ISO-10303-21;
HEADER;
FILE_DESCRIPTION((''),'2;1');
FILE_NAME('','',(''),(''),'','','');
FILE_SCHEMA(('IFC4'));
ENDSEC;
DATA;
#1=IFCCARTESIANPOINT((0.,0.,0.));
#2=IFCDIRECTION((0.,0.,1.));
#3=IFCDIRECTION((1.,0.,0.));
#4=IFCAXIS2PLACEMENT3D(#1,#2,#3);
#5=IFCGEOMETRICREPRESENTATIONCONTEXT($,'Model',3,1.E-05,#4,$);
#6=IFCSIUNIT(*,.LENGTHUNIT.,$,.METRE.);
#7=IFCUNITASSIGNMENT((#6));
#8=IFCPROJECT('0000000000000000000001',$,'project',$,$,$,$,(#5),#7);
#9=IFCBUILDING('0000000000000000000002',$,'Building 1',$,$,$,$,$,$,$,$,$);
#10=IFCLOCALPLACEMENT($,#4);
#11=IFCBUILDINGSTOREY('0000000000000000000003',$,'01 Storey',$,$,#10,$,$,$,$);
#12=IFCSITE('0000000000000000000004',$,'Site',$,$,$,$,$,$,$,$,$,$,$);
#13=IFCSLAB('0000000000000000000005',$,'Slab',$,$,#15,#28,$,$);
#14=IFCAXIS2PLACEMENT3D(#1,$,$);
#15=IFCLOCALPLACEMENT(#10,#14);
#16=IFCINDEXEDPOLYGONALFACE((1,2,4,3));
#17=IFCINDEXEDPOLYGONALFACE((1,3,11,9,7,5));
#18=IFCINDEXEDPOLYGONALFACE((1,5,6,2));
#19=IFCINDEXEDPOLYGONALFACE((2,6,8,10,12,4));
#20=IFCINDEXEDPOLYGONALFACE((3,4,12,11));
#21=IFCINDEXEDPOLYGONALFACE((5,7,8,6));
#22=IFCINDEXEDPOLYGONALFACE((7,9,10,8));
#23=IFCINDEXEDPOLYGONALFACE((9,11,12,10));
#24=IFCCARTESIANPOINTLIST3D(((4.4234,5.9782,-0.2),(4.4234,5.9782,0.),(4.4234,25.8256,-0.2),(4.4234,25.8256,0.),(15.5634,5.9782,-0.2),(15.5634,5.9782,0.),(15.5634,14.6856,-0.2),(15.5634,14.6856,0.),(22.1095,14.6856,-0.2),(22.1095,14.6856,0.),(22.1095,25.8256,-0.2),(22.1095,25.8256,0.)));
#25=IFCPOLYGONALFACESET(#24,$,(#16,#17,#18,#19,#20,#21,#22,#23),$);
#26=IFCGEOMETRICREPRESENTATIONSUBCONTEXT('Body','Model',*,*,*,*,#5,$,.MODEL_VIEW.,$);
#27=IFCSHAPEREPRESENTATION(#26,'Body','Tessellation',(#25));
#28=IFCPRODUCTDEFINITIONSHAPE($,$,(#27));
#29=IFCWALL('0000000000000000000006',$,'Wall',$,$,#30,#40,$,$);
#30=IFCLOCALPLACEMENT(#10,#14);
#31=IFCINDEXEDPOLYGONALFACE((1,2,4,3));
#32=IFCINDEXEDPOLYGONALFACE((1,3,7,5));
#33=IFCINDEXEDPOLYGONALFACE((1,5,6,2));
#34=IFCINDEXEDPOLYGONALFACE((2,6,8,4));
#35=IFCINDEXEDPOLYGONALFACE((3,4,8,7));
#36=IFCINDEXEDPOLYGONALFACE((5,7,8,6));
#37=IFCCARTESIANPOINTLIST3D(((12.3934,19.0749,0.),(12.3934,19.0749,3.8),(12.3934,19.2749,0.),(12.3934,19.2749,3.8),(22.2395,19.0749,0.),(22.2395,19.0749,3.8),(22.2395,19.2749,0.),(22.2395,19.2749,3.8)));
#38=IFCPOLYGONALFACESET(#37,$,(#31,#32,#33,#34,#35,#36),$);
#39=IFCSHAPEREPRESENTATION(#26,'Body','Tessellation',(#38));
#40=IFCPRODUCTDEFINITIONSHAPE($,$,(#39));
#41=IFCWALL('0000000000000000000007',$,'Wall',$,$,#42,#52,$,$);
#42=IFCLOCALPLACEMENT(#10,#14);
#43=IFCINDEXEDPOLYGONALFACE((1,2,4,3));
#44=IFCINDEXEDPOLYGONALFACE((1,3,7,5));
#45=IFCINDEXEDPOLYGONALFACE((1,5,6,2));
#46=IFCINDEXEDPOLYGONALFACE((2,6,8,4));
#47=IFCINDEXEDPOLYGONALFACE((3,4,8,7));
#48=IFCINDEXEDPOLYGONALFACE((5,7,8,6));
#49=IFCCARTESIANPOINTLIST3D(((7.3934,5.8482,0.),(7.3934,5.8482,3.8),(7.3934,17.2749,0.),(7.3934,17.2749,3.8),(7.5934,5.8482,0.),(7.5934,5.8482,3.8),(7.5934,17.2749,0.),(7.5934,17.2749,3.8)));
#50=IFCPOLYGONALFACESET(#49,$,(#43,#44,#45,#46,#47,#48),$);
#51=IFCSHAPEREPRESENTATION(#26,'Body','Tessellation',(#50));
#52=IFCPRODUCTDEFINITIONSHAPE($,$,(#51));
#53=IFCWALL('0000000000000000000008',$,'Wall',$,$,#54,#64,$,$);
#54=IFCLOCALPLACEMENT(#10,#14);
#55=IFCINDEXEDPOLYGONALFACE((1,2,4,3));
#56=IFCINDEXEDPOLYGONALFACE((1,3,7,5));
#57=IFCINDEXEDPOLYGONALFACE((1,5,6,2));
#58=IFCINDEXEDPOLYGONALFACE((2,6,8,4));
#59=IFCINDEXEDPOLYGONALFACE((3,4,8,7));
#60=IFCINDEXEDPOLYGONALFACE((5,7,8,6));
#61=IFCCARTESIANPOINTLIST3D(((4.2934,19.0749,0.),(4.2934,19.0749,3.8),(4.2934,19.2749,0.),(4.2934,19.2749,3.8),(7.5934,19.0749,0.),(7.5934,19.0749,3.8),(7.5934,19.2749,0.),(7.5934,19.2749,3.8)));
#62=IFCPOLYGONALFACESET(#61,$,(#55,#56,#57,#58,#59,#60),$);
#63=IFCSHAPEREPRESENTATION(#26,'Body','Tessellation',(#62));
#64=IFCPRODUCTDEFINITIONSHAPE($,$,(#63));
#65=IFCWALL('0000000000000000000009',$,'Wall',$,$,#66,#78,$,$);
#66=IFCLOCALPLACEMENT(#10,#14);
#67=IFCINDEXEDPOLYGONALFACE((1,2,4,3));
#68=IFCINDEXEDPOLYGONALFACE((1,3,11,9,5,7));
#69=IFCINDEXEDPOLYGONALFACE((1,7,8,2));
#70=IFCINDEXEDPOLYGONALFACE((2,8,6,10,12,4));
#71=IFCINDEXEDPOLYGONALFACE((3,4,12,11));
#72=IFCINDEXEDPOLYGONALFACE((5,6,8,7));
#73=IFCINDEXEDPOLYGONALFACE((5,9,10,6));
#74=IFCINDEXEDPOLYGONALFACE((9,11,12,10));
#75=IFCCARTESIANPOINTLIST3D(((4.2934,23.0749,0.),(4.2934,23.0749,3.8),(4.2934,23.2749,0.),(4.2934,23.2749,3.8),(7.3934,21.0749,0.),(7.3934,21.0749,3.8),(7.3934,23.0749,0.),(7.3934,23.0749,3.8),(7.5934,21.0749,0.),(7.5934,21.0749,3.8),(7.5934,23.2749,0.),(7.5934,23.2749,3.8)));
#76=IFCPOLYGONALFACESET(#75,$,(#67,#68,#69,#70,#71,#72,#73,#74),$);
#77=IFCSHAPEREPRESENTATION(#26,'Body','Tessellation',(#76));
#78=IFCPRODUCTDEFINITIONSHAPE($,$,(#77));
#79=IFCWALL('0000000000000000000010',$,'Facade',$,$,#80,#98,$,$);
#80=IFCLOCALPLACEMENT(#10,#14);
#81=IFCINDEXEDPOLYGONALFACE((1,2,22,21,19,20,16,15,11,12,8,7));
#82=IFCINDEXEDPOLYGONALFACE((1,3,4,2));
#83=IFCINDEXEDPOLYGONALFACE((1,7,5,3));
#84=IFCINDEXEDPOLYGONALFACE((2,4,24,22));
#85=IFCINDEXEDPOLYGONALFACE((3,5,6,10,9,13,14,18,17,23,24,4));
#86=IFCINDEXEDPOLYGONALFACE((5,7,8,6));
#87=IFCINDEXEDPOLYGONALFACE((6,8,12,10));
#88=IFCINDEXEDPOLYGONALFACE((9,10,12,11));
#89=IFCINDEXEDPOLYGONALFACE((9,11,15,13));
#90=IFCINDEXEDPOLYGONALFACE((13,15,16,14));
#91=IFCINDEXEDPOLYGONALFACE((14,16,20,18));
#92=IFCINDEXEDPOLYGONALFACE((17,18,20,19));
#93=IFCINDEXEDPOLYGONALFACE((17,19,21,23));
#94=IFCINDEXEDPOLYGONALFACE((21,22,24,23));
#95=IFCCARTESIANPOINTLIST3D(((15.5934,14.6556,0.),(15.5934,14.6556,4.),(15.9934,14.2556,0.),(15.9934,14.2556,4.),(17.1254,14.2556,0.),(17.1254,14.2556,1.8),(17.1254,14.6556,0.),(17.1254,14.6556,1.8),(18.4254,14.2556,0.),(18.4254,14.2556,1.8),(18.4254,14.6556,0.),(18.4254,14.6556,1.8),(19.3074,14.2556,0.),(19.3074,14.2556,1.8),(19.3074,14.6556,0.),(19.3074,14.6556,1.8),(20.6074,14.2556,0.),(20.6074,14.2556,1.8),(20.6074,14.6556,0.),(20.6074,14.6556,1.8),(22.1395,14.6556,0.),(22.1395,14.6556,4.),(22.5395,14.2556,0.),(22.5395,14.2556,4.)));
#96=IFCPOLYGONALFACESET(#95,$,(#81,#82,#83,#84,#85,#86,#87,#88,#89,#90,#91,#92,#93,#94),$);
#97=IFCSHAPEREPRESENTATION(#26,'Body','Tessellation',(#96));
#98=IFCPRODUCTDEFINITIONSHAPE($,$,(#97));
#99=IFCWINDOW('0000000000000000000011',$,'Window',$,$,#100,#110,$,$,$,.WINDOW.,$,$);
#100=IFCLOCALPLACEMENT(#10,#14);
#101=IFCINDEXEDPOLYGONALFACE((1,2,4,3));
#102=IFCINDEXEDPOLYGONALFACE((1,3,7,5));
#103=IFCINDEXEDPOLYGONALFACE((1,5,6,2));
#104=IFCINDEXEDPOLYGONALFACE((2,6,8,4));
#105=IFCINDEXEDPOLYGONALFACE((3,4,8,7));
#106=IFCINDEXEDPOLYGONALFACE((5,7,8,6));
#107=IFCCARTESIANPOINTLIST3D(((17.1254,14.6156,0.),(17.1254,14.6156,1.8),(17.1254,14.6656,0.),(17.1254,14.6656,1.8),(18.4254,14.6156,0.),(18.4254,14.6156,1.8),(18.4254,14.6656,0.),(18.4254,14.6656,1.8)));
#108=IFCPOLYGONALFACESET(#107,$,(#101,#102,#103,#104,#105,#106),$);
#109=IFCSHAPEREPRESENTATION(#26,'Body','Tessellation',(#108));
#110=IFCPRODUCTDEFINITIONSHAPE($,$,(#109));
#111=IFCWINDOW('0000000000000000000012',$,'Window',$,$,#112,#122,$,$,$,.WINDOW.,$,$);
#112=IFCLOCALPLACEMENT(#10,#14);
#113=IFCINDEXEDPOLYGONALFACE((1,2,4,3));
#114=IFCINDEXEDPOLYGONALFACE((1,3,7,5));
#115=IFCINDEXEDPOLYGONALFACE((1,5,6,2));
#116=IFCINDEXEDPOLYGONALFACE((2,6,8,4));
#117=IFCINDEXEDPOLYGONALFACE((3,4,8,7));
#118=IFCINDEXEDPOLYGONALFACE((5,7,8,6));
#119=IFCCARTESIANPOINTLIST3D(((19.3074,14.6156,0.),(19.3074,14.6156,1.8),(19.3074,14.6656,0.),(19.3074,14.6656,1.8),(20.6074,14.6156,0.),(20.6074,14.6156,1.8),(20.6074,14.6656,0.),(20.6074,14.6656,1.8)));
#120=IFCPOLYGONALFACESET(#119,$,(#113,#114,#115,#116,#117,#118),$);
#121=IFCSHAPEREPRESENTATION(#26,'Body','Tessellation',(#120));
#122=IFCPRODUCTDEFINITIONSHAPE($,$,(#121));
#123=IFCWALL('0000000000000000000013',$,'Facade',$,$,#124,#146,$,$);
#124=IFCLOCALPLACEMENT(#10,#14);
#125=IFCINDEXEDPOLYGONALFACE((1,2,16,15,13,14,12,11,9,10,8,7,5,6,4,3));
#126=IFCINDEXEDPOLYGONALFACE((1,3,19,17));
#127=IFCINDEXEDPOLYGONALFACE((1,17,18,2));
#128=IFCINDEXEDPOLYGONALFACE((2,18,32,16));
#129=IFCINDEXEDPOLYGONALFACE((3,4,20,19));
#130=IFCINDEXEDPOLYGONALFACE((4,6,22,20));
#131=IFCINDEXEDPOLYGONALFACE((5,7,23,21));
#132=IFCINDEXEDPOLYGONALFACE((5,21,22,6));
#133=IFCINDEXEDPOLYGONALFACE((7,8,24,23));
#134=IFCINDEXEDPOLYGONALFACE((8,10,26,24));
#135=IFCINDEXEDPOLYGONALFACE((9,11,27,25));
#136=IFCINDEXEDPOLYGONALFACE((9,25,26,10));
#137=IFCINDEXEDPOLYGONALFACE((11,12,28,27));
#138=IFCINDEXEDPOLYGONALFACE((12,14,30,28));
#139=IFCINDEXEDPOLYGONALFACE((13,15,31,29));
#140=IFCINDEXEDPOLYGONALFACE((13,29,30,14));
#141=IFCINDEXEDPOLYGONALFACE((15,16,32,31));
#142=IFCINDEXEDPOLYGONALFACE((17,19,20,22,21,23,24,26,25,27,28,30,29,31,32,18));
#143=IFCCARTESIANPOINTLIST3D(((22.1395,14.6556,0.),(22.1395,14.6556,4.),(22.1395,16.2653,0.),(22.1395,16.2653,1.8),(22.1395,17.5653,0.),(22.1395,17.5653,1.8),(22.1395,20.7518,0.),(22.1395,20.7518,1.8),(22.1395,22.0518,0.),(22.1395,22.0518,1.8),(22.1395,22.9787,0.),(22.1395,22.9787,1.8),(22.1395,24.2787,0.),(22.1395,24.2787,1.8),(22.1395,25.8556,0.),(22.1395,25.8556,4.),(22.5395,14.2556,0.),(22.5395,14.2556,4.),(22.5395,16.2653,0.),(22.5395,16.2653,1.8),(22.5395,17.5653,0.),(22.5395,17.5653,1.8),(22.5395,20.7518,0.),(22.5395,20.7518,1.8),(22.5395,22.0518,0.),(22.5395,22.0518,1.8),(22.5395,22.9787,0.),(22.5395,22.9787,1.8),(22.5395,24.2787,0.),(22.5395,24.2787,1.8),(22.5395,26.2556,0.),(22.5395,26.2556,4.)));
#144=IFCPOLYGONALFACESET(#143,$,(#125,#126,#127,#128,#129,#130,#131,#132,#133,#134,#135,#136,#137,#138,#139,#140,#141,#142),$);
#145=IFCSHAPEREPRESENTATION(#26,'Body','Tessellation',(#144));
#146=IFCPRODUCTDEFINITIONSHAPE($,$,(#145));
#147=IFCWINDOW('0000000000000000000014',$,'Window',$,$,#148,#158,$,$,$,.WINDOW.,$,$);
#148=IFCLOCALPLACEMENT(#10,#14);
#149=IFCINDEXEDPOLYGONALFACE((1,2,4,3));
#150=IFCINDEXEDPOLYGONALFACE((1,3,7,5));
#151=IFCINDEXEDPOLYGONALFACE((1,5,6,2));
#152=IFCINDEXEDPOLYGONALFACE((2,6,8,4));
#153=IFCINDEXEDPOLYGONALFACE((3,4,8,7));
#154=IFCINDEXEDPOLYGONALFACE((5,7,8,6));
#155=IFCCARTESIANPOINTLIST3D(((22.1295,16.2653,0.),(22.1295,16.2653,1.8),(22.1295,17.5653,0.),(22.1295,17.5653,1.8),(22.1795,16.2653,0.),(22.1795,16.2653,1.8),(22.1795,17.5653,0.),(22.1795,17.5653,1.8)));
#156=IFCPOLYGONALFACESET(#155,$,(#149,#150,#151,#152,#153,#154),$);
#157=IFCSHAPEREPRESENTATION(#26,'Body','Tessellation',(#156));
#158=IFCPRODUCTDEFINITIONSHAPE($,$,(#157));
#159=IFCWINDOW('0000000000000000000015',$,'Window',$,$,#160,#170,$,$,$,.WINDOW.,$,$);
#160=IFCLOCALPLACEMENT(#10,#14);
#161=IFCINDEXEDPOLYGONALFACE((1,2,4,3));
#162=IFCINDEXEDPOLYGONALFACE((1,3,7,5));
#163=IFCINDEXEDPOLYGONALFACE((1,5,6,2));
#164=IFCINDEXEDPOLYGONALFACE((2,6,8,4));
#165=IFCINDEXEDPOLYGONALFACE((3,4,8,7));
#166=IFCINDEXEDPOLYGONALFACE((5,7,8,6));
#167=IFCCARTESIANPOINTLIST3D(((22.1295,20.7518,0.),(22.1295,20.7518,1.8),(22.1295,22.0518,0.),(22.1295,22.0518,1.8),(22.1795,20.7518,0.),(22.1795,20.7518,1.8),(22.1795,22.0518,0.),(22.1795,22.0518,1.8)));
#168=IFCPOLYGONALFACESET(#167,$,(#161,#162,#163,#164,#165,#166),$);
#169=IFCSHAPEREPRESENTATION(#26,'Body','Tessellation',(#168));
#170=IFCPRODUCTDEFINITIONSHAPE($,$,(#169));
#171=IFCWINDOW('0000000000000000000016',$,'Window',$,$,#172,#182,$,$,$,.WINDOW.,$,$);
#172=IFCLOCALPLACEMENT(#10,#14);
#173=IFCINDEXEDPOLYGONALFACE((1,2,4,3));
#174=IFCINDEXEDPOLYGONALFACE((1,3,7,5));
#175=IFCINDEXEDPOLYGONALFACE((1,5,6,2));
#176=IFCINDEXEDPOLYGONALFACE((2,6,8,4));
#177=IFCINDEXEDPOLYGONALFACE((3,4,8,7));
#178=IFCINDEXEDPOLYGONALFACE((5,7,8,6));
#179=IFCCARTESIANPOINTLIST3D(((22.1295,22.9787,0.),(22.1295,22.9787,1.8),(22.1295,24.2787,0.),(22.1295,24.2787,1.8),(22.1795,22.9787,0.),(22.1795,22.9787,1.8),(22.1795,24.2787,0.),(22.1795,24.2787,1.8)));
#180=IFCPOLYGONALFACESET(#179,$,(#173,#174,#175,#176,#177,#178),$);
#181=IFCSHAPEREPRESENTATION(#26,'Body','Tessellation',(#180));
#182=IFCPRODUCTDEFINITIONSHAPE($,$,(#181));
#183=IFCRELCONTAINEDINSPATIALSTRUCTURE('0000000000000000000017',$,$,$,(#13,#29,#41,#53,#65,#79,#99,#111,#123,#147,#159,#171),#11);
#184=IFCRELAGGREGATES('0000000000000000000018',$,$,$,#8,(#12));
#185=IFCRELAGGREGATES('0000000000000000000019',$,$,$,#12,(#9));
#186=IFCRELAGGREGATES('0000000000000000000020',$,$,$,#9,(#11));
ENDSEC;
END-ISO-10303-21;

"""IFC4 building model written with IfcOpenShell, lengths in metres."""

from ifc_helpers import new_model, si_unit, origin_with_axes, place, context, subcontext, project, spatial, line, indexed_curve, outline, extrude, element, fill, save


model = new_model("IFC4")

# Units and contexts
model_context = context("Model", 3, precision=1e-05, world=origin_with_axes())
body_context = subcontext(model_context, "Body", "Model", "MODEL_VIEW")
ifc_project = project(units=[si_unit("LENGTHUNIT", "METRE")], contexts=[model_context])

# Site, building, storey
site = spatial("IfcSite", under=ifc_project, Name="Site")
building = spatial("IfcBuilding", under=site, Name="Building 1")
storey_placement = place(None, origin_with_axes())
storey = spatial("IfcBuildingStorey", under=building, at=storey_placement, Name="01 Storey")

# Slab
slab_placement = place(storey_placement, origin_with_axes())
element("IfcSlab", 1, at=slab_placement, inside=storey, Name="Slab", context=body_context, shape_type="SweptSolid", body=[
    extrude(outline(indexed_curve([(15.5634, 14.6856), (22.1095, 14.6856), (22.1095, 25.8256), (4.4234, 25.8256), (4.4234, 5.9782), (15.5634, 5.9782)], segments=[line(1, 2), line(2, 3), line(3, 4), line(4, 5), line(5, 6)])), origin_with_axes(), (0.0, 0.0, -1.0), 0.2),
])

# Walls
wall_1_placement = place(storey_placement, origin_with_axes())
element("IfcWall", 2, at=wall_1_placement, inside=storey, Name="Wall", context=body_context, shape_type="SweptSolid", body=[
    extrude(outline(indexed_curve([(22.2395, 19.2749), (12.3934, 19.2749), (12.3934, 19.0749), (22.2395, 19.0749)], segments=[line(1, 2), line(2, 3), line(3, 4)])), origin_with_axes(), (0.0, 0.0, 1.0), 3.8),
])
wall_2_placement = place(storey_placement, origin_with_axes())
element("IfcWall", 3, at=wall_2_placement, inside=storey, Name="Wall", context=body_context, shape_type="SweptSolid", body=[
    extrude(outline(indexed_curve([(7.5934, 17.2749), (7.3934, 17.2749), (7.3934, 5.8482), (7.5934, 5.8482)], segments=[line(1, 2), line(2, 3), line(3, 4)])), origin_with_axes(), (0.0, 0.0, 1.0), 3.8),
])
wall_3_placement = place(storey_placement, origin_with_axes())
element("IfcWall", 4, at=wall_3_placement, inside=storey, Name="Wall", context=body_context, shape_type="SweptSolid", body=[
    extrude(outline(indexed_curve([(7.5934, 19.2749), (4.2934, 19.2749), (4.2934, 19.0749), (7.5934, 19.0749)], segments=[line(1, 2), line(2, 3), line(3, 4)])), origin_with_axes(), (0.0, 0.0, 1.0), 3.8),
])
wall_4_placement = place(storey_placement, origin_with_axes())
element("IfcWall", 5, at=wall_4_placement, inside=storey, Name="Wall", context=body_context, shape_type="SweptSolid", body=[
    extrude(outline(indexed_curve([(7.5934, 23.2749), (4.2934, 23.2749), (4.2934, 23.0749), (7.3934, 23.0749), (7.3934, 21.0749), (7.5934, 21.0749)], segments=[line(1, 2), line(2, 3), line(3, 4), line(4, 5), line(5, 6)])), origin_with_axes(), (0.0, 0.0, 1.0), 3.8),
])

# Walls, openings, windows
wall_5_placement = place(storey_placement, origin_with_axes())
wall_5 = element("IfcWall", 6, at=wall_5_placement, inside=storey, Name="Facade", context=body_context, shape_type="SweptSolid", body=[
    extrude(outline(indexed_curve([(15.5934, 14.6556), (22.1395, 14.6556), (22.5395, 14.2556), (15.9934, 14.2556)], segments=[line(1, 2), line(2, 3), line(3, 4)])), origin_with_axes(), (0.0, 0.0, 1.0), 4.0),
])
opening_1_placement = place(wall_5_placement, origin_with_axes())
opening_1 = element("IfcOpeningElement", 7, at=opening_1_placement, cuts=wall_5, context=body_context, shape_type="SweptSolid", body=[
    extrude(outline(indexed_curve([(17.1254, 14.2156), (17.1254, 14.7156), (18.4254, 14.7156), (18.4254, 14.2156)], segments=[line(1, 2), line(2, 3), line(3, 4)])), origin_with_axes(), (0.0, 0.0, 1.0), 1.8),
])
opening_2_placement = place(wall_5_placement, origin_with_axes())
opening_2 = element("IfcOpeningElement", 8, at=opening_2_placement, cuts=wall_5, context=body_context, shape_type="SweptSolid", body=[
    extrude(outline(indexed_curve([(19.3074, 14.2156), (19.3074, 14.7156), (20.6074, 14.7156), (20.6074, 14.2156)], segments=[line(1, 2), line(2, 3), line(3, 4)])), origin_with_axes(), (0.0, 0.0, 1.0), 1.8),
])
window_1_placement = place(storey_placement, origin_with_axes())
window_1 = element("IfcWindow", 9, at=window_1_placement, inside=storey, Name="Window", PredefinedType="WINDOW", context=body_context, shape_type="SweptSolid", body=[
    extrude(outline(indexed_curve([(17.1254, 14.6156), (17.1254, 14.6656), (18.4254, 14.6656), (18.4254, 14.6156)], segments=[line(1, 2), line(2, 3), line(3, 4)])), origin_with_axes(), (0.0, 0.0, 1.0), 1.8),
])
fill(opening_1, window_1)
window_2_placement = place(storey_placement, origin_with_axes())
window_2 = element("IfcWindow", 10, at=window_2_placement, inside=storey, Name="Window", PredefinedType="WINDOW", context=body_context, shape_type="SweptSolid", body=[
    extrude(outline(indexed_curve([(19.3074, 14.6156), (19.3074, 14.6656), (20.6074, 14.6656), (20.6074, 14.6156)], segments=[line(1, 2), line(2, 3), line(3, 4)])), origin_with_axes(), (0.0, 0.0, 1.0), 1.8),
])
fill(opening_2, window_2)
wall_6_placement = place(storey_placement, origin_with_axes())
wall_6 = element("IfcWall", 11, at=wall_6_placement, inside=storey, Name="Facade", context=body_context, shape_type="SweptSolid", body=[
    extrude(outline(indexed_curve([(22.1395, 14.6556), (22.1395, 25.8556), (22.5395, 26.2556), (22.5395, 14.2556)], segments=[line(1, 2), line(2, 3), line(3, 4)])), origin_with_axes(), (0.0, 0.0, 1.0), 4.0),
])
opening_3_placement = place(wall_6_placement, origin_with_axes())
opening_3 = element("IfcOpeningElement", 12, at=opening_3_placement, cuts=wall_6, context=body_context, shape_type="SweptSolid", body=[
    extrude(outline(indexed_curve([(22.5795, 16.2653), (22.0795, 16.2653), (22.0795, 17.5653), (22.5795, 17.5653)], segments=[line(1, 2), line(2, 3), line(3, 4)])), origin_with_axes(), (0.0, 0.0, 1.0), 1.8),
])
opening_4_placement = place(wall_6_placement, origin_with_axes())
opening_4 = element("IfcOpeningElement", 13, at=opening_4_placement, cuts=wall_6, context=body_context, shape_type="SweptSolid", body=[
    extrude(outline(indexed_curve([(22.5795, 20.7518), (22.0795, 20.7518), (22.0795, 22.0518), (22.5795, 22.0518)], segments=[line(1, 2), line(2, 3), line(3, 4)])), origin_with_axes(), (0.0, 0.0, 1.0), 1.8),
])
opening_5_placement = place(wall_6_placement, origin_with_axes())
opening_5 = element("IfcOpeningElement", 14, at=opening_5_placement, cuts=wall_6, context=body_context, shape_type="SweptSolid", body=[
    extrude(outline(indexed_curve([(22.5795, 22.9787), (22.0795, 22.9787), (22.0795, 24.2787), (22.5795, 24.2787)], segments=[line(1, 2), line(2, 3), line(3, 4)])), origin_with_axes(), (0.0, 0.0, 1.0), 1.8),
])
window_3_placement = place(storey_placement, origin_with_axes())
window_3 = element("IfcWindow", 15, at=window_3_placement, inside=storey, Name="Window", PredefinedType="WINDOW", context=body_context, shape_type="SweptSolid", body=[
    extrude(outline(indexed_curve([(22.1795, 16.2653), (22.1295, 16.2653), (22.1295, 17.5653), (22.1795, 17.5653)], segments=[line(1, 2), line(2, 3), line(3, 4)])), origin_with_axes(), (0.0, 0.0, 1.0), 1.8),
])
fill(opening_3, window_3)
window_4_placement = place(storey_placement, origin_with_axes())
window_4 = element("IfcWindow", 16, at=window_4_placement, inside=storey, Name="Window", PredefinedType="WINDOW", context=body_context, shape_type="SweptSolid", body=[
    extrude(outline(indexed_curve([(22.1795, 20.7518), (22.1295, 20.7518), (22.1295, 22.0518), (22.1795, 22.0518)], segments=[line(1, 2), line(2, 3), line(3, 4)])), origin_with_axes(), (0.0, 0.0, 1.0), 1.8),
])
fill(opening_4, window_4)
window_5_placement = place(storey_placement, origin_with_axes())
window_5 = element("IfcWindow", 17, at=window_5_placement, inside=storey, Name="Window", PredefinedType="WINDOW", context=body_context, shape_type="SweptSolid", body=[
    extrude(outline(indexed_curve([(22.1795, 22.9787), (22.1295, 22.9787), (22.1295, 24.2787), (22.1795, 24.2787)], segments=[line(1, 2), line(2, 3), line(3, 4)])), origin_with_axes(), (0.0, 0.0, 1.0), 1.8),
])
fill(opening_5, window_5)

save(model, "model.ifc")
